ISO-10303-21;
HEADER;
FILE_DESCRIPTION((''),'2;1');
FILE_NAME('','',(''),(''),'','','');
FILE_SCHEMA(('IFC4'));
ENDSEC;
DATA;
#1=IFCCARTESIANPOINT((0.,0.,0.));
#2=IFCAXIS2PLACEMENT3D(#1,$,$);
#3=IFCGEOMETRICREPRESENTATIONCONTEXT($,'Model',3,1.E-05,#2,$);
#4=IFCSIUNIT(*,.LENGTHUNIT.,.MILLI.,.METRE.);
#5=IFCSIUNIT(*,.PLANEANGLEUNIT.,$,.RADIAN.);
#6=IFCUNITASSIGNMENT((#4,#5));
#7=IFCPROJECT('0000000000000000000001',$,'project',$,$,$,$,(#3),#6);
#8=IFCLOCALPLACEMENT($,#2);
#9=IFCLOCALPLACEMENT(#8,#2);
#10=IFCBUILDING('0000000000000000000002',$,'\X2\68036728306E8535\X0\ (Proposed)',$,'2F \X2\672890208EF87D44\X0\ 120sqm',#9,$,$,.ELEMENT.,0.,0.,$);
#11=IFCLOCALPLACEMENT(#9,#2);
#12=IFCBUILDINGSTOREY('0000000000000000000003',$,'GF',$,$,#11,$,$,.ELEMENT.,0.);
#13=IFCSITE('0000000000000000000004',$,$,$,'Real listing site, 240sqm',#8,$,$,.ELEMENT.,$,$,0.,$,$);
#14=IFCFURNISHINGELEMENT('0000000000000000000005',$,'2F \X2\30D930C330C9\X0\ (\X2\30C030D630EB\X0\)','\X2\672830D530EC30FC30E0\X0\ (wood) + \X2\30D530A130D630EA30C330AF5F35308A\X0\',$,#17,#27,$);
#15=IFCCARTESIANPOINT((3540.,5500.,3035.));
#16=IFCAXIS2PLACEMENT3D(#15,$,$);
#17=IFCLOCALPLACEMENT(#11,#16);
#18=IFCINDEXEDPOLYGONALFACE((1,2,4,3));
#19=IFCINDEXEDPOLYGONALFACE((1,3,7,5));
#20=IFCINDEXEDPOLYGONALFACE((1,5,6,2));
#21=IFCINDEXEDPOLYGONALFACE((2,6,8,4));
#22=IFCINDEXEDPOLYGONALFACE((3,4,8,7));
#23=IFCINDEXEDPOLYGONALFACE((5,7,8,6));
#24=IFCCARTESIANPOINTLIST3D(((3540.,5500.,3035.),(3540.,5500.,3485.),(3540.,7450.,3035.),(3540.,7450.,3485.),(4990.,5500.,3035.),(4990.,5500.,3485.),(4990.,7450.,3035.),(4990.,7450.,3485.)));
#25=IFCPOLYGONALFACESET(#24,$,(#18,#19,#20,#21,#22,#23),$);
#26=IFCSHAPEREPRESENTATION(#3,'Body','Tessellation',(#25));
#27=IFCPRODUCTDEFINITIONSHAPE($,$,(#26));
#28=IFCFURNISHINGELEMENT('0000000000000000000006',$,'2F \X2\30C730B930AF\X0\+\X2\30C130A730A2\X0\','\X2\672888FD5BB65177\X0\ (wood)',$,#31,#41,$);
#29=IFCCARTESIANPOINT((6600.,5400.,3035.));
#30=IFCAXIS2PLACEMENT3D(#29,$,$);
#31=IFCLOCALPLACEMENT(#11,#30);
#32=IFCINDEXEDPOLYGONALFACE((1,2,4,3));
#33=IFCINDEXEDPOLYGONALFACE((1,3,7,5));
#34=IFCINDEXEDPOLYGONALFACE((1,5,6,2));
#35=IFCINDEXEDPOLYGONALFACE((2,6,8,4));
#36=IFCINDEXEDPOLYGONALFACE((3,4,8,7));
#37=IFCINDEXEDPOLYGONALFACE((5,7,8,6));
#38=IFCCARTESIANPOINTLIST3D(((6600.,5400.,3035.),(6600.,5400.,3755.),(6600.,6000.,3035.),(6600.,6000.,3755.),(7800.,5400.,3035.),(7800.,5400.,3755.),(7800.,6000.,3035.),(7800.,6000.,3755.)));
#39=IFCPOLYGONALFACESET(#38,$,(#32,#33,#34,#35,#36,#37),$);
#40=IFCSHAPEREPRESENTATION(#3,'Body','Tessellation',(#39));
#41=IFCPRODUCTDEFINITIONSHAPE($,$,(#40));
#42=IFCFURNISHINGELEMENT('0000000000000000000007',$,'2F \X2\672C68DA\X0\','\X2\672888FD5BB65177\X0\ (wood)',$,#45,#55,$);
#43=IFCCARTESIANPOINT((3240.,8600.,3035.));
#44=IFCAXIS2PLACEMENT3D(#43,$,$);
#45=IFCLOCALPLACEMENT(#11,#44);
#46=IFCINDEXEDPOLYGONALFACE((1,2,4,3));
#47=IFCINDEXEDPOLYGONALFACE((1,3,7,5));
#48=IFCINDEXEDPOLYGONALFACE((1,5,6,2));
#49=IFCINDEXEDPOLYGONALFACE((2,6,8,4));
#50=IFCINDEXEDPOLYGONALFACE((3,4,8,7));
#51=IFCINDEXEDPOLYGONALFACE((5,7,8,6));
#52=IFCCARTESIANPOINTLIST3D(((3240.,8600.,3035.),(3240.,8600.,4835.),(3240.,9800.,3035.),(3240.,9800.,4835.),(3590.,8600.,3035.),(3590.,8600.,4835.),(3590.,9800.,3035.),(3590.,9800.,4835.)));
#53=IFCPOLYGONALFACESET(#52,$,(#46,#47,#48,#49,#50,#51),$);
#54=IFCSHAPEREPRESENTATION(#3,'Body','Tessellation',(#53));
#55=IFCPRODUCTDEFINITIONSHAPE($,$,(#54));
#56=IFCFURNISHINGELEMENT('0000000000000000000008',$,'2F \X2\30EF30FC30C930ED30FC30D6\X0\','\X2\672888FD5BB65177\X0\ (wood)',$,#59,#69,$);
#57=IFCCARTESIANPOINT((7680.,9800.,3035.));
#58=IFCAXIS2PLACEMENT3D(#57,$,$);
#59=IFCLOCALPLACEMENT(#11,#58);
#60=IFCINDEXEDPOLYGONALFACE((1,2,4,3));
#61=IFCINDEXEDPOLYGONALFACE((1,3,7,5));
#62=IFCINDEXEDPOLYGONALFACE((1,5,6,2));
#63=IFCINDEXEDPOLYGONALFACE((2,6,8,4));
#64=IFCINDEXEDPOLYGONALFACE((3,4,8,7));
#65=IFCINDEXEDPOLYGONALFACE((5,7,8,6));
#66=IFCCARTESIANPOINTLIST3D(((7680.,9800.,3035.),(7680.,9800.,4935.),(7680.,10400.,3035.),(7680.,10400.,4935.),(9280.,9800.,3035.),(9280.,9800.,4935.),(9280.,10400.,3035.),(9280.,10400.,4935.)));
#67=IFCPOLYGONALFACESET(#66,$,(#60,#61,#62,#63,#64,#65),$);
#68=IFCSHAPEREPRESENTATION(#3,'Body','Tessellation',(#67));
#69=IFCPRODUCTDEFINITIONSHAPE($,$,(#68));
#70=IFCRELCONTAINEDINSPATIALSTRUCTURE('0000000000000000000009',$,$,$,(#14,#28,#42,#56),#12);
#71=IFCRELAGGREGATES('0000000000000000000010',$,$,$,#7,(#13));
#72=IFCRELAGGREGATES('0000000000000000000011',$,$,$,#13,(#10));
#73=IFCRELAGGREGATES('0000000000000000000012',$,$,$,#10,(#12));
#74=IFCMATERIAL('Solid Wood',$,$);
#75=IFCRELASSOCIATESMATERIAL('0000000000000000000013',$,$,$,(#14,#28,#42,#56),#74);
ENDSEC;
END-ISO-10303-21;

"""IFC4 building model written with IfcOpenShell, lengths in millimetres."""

from ifc_helpers import new_model, si_unit, frame, frame_2d, origin, place, context, project, spatial, rectangle, extrude, material, element, save


model = new_model("IFC4")

# Units and contexts
model_context = context("Model", 3, precision=1e-05, world=origin())
ifc_project = project(units=[si_unit("LENGTHUNIT", "METRE", prefix="MILLI"), si_unit("PLANEANGLEUNIT", "RADIAN")], contexts=[model_context])

# Site, building, storey
site_placement = place(None, origin())
site = spatial("IfcSite", under=ifc_project, at=site_placement, ObjectType="Real listing site, 240sqm", CompositionType="ELEMENT", RefElevation=0.0)
building_placement = place(site_placement, origin())
building = spatial("IfcBuilding", under=site, at=building_placement, Name="栃木の蔵 (Proposed)", ObjectType="2F 木造軸組 120sqm", CompositionType="ELEMENT", ElevationOfRefHeight=0.0, ElevationOfTerrain=0.0)
storey_placement = place(building_placement, origin())
storey = spatial("IfcBuildingStorey", under=building, at=storey_placement, Name="GF", CompositionType="ELEMENT", Elevation=0.0)

# Shared definitions
ifc_material_1 = material(Name="Solid Wood")

# Furnishing elements
furnishing_1_placement = place(storey_placement, frame((3540.0, 5500.0, 3035.0)))
element("IfcFurnishingElement", 1, at=furnishing_1_placement, inside=storey, material=ifc_material_1, Name="2F ベッド (ダブル)", Description="木フレーム (wood) + ファブリック張り", context=model_context, shape_type="SweptSolid", body=[
    extrude(rectangle(XDim=1450.0, YDim=1950.0, at=frame_2d((725.0, 975.0))), frame((3540.0, 5500.0, 3035.0)), (0.0, 0.0, 1.0), 450.0),
])
furnishing_2_placement = place(storey_placement, frame((6600.0, 5400.0, 3035.0)))
element("IfcFurnishingElement", 2, at=furnishing_2_placement, inside=storey, material=ifc_material_1, Name="2F デスク+チェア", Description="木製家具 (wood)", context=model_context, shape_type="SweptSolid", body=[
    extrude(rectangle(XDim=1200.0, YDim=600.0, at=frame_2d((600.0, 300.0))), frame((6600.0, 5400.0, 3035.0)), (0.0, 0.0, 1.0), 720.0),
])
furnishing_3_placement = place(storey_placement, frame((3240.0, 8600.0, 3035.0)))
element("IfcFurnishingElement", 3, at=furnishing_3_placement, inside=storey, material=ifc_material_1, Name="2F 本棚", Description="木製家具 (wood)", context=model_context, shape_type="SweptSolid", body=[
    extrude(rectangle(XDim=350.0, YDim=1200.0, at=frame_2d((175.0, 600.0))), frame((3240.0, 8600.0, 3035.0)), (0.0, 0.0, 1.0), 1800.0),
])
furnishing_4_placement = place(storey_placement, frame((7680.0, 9800.0, 3035.0)))
element("IfcFurnishingElement", 4, at=furnishing_4_placement, inside=storey, material=ifc_material_1, Name="2F ワードローブ", Description="木製家具 (wood)", context=model_context, shape_type="SweptSolid", body=[
    extrude(rectangle(XDim=1600.0, YDim=600.0, at=frame_2d((800.0, 300.0))), frame((7680.0, 9800.0, 3035.0)), (0.0, 0.0, 1.0), 1900.0),
])

save(model, "model.ifc")
